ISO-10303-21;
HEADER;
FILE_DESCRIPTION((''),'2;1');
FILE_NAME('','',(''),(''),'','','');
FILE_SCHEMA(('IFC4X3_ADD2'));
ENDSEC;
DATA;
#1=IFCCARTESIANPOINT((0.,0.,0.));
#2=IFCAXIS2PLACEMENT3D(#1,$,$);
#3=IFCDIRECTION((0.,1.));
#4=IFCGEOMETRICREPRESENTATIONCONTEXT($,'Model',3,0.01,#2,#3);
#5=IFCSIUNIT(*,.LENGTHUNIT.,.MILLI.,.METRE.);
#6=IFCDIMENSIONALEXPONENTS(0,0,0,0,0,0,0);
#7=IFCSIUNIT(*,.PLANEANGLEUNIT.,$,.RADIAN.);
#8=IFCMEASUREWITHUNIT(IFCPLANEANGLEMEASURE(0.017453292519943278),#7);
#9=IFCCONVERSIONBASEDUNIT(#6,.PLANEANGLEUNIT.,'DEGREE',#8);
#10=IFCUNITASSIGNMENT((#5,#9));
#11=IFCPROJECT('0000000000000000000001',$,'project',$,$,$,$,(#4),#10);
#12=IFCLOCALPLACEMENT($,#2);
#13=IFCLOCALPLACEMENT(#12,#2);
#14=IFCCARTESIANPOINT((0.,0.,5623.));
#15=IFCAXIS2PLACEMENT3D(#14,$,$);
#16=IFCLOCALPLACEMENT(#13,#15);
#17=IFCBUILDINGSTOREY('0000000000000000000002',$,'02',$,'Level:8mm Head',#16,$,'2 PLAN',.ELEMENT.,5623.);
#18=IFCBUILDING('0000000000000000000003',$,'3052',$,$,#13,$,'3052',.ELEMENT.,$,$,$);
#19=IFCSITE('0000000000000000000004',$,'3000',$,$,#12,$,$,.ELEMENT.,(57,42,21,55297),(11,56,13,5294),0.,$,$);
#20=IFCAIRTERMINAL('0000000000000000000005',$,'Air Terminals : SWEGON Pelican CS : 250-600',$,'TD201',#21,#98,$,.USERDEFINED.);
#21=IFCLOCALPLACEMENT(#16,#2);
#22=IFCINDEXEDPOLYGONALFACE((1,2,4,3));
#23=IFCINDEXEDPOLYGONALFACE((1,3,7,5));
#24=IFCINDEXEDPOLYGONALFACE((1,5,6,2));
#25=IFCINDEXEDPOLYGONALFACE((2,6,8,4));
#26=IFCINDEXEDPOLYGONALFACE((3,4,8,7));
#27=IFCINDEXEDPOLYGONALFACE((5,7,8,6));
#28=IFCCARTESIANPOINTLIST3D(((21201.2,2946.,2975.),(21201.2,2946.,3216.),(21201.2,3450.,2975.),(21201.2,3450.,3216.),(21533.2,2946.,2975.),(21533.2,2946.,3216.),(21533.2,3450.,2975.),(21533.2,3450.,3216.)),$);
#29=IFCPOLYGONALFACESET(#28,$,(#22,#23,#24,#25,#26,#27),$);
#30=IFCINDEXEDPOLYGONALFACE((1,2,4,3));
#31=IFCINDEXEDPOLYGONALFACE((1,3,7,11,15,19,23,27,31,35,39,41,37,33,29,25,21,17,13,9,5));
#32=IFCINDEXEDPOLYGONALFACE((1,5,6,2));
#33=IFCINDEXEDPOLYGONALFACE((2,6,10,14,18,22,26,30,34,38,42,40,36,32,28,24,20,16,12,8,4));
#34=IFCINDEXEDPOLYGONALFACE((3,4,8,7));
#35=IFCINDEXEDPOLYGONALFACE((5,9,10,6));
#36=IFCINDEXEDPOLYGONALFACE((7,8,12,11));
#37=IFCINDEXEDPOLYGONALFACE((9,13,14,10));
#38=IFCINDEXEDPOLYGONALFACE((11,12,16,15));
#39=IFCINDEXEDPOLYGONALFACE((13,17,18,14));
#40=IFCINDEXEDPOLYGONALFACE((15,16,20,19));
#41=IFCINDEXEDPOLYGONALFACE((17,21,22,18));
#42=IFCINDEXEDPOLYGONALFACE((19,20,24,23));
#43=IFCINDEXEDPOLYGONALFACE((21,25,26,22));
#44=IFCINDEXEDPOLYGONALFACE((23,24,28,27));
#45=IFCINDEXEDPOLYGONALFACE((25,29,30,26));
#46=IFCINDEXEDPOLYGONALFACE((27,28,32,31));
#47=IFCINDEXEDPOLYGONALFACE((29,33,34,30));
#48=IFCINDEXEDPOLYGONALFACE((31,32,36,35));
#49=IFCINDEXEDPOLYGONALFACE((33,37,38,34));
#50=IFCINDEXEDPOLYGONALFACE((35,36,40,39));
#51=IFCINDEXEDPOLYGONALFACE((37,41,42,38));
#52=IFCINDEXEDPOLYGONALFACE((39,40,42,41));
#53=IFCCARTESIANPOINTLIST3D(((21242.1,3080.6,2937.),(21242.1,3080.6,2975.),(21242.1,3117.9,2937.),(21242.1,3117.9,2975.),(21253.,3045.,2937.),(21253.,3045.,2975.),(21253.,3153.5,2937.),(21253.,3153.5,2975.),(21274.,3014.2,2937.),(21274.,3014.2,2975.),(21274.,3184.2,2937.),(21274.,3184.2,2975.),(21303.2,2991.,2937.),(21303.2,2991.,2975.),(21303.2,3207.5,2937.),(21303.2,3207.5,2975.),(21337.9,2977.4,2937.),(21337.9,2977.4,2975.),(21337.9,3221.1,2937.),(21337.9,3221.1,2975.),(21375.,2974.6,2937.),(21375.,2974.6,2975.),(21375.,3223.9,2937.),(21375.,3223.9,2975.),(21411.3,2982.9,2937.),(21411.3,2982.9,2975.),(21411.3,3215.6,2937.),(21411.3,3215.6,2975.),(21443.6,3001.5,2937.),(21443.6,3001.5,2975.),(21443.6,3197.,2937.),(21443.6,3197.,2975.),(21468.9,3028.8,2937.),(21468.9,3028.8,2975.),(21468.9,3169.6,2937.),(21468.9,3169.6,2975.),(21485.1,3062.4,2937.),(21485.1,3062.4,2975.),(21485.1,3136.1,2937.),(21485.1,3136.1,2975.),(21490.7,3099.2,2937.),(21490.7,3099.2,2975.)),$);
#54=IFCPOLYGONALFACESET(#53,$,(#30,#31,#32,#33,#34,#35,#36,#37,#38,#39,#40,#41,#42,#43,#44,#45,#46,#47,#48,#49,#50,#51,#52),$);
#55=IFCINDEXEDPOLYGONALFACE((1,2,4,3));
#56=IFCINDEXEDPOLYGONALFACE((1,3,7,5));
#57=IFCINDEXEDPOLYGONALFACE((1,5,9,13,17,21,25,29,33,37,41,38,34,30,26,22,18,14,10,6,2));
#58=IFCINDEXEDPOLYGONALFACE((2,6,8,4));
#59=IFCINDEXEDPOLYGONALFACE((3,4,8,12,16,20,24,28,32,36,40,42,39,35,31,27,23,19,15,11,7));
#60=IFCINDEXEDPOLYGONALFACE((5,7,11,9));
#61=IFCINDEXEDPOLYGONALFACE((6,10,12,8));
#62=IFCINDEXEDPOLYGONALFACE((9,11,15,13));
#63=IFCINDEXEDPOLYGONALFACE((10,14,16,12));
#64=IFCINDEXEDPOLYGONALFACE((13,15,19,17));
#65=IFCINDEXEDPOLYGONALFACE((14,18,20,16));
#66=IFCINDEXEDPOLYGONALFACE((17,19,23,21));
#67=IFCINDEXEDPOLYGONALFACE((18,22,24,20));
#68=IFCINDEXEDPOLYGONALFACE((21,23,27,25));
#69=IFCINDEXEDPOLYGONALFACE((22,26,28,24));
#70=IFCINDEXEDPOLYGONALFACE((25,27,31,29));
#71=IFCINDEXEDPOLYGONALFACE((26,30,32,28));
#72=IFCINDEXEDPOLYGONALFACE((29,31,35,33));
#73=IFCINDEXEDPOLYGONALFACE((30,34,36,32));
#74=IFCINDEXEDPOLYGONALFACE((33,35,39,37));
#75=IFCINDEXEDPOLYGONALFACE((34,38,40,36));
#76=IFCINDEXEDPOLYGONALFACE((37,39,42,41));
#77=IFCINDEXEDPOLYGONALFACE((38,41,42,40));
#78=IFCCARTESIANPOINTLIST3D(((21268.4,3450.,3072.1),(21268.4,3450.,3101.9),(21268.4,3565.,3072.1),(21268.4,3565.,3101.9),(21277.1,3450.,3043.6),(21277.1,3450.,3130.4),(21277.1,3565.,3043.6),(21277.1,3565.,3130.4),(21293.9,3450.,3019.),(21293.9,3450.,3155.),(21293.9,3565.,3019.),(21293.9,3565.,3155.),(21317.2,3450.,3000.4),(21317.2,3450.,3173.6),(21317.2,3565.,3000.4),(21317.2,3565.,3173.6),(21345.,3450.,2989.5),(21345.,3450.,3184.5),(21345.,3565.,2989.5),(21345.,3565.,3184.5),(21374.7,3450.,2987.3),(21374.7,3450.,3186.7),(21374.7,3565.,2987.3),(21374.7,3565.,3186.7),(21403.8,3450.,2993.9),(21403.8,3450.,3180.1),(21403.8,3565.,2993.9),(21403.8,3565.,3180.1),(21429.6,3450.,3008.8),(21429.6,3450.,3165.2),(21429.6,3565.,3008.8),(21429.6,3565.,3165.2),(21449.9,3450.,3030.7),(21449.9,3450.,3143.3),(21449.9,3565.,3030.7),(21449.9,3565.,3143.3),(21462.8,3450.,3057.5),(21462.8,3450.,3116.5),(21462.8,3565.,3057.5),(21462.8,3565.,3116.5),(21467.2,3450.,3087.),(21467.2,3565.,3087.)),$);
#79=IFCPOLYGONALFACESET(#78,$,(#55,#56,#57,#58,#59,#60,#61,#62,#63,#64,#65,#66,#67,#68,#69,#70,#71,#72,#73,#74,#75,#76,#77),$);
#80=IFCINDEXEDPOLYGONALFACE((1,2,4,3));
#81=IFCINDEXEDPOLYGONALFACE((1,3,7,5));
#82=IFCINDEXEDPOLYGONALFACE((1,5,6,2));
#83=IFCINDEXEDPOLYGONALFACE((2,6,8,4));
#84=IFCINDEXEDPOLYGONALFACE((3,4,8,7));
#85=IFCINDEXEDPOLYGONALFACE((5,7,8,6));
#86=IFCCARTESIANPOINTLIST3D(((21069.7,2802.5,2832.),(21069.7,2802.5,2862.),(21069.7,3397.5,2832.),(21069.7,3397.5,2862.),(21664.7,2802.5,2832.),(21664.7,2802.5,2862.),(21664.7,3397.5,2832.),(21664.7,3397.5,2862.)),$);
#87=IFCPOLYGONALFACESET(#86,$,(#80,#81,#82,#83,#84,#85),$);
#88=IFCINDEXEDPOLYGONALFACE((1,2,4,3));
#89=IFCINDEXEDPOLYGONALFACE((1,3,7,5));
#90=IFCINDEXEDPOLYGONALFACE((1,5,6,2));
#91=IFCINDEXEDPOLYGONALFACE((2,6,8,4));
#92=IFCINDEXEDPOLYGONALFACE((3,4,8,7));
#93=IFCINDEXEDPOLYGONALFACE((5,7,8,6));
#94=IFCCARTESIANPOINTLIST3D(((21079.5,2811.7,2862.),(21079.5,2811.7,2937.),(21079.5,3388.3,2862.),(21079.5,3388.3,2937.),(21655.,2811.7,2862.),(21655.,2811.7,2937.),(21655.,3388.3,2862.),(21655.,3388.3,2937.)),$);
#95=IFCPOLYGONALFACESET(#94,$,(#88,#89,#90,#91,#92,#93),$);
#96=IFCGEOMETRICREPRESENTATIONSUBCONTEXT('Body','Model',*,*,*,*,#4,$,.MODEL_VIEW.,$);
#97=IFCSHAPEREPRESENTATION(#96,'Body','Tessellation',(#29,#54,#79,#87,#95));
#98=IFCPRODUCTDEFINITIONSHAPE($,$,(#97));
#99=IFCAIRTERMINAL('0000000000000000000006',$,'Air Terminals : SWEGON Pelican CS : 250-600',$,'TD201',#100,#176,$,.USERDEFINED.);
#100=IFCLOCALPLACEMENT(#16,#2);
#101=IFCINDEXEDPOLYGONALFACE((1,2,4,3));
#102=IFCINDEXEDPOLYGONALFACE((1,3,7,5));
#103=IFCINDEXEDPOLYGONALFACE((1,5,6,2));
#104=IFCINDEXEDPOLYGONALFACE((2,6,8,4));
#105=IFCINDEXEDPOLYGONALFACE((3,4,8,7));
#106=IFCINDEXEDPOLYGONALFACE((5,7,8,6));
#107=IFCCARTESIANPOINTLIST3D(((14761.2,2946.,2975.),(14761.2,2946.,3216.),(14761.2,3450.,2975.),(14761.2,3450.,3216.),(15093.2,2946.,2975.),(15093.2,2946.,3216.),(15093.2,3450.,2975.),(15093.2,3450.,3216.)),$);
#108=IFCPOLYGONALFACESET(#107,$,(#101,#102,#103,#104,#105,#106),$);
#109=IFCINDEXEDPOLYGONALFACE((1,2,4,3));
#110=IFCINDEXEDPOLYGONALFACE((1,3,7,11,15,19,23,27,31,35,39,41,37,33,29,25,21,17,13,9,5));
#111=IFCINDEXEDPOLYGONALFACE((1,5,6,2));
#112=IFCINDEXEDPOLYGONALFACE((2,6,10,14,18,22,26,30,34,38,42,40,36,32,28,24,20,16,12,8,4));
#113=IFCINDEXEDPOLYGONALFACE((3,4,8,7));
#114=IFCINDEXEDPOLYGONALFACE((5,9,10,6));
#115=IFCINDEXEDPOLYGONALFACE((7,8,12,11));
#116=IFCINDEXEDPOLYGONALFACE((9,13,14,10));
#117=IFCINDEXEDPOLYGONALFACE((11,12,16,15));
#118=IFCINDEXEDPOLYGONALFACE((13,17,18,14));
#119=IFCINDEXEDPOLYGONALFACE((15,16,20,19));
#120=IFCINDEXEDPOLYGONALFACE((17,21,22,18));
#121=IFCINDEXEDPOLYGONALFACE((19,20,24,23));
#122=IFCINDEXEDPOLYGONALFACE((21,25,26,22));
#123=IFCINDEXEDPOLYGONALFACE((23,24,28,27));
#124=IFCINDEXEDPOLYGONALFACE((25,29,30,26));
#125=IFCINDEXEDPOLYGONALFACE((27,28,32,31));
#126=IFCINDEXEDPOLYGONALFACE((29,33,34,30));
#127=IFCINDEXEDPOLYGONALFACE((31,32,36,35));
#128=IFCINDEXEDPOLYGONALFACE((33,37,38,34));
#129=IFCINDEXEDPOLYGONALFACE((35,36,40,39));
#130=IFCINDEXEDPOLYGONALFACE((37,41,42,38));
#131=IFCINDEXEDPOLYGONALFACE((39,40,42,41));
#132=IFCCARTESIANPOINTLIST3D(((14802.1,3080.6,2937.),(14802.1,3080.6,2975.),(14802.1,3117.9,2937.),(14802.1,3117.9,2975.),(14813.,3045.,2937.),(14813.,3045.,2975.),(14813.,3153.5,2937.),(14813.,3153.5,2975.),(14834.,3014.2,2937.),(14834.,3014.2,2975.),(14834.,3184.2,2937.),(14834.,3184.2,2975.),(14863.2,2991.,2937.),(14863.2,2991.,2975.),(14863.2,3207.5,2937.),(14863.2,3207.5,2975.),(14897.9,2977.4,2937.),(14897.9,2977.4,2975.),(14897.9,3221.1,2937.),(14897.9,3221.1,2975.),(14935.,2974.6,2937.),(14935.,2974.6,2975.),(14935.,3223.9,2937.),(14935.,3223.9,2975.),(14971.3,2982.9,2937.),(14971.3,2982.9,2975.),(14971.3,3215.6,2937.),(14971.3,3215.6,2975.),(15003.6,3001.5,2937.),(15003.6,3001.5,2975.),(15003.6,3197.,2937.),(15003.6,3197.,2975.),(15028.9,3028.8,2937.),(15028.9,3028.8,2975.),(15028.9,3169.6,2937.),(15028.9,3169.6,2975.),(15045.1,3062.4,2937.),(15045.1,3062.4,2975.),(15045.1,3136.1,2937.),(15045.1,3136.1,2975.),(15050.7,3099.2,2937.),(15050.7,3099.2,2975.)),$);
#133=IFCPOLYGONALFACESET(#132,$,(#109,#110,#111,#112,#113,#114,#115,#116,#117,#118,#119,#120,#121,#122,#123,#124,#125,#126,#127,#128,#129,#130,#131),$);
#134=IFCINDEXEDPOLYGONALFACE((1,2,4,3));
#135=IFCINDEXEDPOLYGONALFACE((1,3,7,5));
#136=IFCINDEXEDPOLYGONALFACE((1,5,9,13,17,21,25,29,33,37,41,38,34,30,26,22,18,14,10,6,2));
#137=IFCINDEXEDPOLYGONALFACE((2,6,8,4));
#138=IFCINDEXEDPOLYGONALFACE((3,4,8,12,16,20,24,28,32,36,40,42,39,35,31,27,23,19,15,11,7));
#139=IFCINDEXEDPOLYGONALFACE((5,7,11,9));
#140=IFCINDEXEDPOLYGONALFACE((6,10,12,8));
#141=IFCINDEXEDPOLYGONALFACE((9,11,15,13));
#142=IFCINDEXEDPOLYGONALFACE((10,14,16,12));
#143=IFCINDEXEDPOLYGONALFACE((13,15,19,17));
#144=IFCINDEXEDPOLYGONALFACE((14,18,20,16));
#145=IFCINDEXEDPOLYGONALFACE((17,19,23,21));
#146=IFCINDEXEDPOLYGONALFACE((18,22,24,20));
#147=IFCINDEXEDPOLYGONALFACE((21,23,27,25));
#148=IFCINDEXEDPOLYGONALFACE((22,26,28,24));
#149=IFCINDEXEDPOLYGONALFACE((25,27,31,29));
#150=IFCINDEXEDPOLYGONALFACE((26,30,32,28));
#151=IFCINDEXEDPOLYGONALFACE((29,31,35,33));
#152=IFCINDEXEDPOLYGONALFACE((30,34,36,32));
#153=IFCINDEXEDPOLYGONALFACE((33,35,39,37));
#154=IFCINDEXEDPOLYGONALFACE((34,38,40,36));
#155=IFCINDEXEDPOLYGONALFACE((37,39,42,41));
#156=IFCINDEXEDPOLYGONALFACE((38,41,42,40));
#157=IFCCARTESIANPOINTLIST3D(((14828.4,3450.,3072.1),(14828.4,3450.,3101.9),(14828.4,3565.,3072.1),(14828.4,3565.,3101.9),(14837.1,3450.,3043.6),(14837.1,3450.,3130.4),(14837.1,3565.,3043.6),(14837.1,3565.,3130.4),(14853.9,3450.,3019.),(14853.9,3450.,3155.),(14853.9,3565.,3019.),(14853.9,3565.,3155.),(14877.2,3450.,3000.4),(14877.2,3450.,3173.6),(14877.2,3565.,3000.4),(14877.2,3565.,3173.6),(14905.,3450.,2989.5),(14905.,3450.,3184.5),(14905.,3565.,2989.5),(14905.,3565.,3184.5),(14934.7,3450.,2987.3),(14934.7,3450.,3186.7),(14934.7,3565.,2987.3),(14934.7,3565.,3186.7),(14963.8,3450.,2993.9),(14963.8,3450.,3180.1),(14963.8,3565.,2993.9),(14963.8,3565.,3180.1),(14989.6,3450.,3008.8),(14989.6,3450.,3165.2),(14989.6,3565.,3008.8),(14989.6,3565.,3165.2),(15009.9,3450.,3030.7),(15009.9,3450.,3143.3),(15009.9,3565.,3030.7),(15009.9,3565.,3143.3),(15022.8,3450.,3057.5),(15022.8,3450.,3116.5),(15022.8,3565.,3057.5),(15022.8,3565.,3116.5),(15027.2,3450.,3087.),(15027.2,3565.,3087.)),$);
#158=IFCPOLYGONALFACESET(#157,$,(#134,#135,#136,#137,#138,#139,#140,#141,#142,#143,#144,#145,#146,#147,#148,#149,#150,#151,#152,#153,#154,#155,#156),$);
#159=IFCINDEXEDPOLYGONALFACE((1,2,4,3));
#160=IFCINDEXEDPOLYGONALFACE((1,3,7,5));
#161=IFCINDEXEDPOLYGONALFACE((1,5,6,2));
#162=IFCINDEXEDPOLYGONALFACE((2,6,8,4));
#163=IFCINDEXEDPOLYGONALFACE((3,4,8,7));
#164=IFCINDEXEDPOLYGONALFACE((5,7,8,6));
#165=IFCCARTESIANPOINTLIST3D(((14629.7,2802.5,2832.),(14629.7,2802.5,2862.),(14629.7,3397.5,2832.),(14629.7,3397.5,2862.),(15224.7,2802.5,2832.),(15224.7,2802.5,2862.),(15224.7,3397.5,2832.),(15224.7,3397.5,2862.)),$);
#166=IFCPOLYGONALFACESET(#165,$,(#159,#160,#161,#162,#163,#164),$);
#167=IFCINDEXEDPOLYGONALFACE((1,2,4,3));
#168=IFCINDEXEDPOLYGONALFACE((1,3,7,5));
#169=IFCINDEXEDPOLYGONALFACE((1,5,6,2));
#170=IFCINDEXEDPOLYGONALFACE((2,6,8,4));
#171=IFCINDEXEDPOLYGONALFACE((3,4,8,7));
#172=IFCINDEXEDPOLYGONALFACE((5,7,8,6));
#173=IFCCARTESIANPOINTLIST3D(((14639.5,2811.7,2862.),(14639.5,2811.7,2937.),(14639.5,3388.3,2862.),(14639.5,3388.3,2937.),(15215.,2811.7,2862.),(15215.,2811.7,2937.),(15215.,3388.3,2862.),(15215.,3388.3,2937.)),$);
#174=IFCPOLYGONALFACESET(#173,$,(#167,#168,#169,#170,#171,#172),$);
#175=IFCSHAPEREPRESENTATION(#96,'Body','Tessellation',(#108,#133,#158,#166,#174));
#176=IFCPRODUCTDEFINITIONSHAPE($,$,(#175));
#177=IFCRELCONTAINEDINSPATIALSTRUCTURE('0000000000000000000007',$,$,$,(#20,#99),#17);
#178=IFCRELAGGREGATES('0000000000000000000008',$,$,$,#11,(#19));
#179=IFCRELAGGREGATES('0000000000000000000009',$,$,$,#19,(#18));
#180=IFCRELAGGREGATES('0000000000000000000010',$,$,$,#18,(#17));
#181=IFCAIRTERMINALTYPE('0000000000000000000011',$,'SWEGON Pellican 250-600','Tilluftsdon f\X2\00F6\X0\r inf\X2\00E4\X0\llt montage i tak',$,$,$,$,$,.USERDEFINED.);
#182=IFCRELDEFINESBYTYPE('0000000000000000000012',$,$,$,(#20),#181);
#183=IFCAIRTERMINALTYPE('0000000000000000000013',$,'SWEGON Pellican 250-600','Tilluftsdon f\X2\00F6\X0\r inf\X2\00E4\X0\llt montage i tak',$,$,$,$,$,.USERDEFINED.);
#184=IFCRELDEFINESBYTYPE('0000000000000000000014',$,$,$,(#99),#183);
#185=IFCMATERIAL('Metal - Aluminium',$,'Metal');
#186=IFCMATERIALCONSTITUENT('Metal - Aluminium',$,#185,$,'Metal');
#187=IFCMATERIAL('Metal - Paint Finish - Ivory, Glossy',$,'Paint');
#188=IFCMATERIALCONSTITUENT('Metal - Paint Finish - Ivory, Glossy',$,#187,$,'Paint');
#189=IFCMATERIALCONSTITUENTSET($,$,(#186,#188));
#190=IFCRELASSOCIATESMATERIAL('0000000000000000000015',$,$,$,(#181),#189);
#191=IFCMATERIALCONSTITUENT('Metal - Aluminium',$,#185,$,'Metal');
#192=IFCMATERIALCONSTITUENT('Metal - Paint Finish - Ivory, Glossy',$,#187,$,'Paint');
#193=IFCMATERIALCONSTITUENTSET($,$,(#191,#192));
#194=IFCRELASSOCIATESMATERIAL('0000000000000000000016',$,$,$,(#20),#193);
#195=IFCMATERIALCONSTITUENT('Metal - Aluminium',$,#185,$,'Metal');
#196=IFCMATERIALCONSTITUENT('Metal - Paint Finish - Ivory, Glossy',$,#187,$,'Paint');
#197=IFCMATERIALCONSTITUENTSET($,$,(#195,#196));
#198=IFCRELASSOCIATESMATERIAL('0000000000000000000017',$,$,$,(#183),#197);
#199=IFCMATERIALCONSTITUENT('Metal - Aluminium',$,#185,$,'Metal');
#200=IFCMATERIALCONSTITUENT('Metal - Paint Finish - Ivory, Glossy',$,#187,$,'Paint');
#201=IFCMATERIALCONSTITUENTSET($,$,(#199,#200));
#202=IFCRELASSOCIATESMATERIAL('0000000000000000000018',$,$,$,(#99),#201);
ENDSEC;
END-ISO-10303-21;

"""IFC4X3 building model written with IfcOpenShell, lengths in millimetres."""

from ifc_helpers import new_model, entity, si_unit, converted_unit, direction, frame, frame_2d, origin, origin_2d_with_axis, place, context, subcontext, project, spatial, rectangle, circle, extrude, source, transform, mapped, material, constituent, constituent_set, type_object, type_shapes, element, save


model = new_model("IFC4X3")

# Units and contexts
model_context = context("Model", 3, precision=0.01, world=origin(), true_north=direction((0.0, 1.0)))
body_context = subcontext(model_context, "Body", "Model", "MODEL_VIEW")
ifc_project = project(units=[si_unit("LENGTHUNIT", "METRE", prefix="MILLI"), converted_unit("PLANEANGLEUNIT", "DEGREE", entity("IfcPlaneAngleMeasure", 0.017453292519943278), si_unit("PLANEANGLEUNIT", "RADIAN"), dimensions=[0, 0, 0, 0, 0, 0, 0])], contexts=[model_context])

# Site, building, storey
site_placement = place(None, origin())
site = spatial("IfcSite", under=ifc_project, at=site_placement, Name="3000", CompositionType="ELEMENT", RefLatitude=(57, 42, 21, 55297), RefLongitude=(11, 56, 13, 5294), RefElevation=0.0)
building_placement = place(site_placement, origin())
building = spatial("IfcBuilding", under=site, at=building_placement, Name="3052", LongName="3052", CompositionType="ELEMENT")
storey_placement = place(building_placement, frame((0.0, 0.0, 5623.0)))
storey = spatial("IfcBuildingStorey", under=building, at=storey_placement, Name="02", ObjectType="Level:8mm Head", LongName="2 PLAN", CompositionType="ELEMENT", Elevation=5623.0)

# Air terminals
ifc_material_1 = material(Name="Metal - Aluminium", Category="Metal")
ifc_material_2 = material(Name="Metal - Paint Finish - Ivory, Glossy", Category="Paint")
ifc_constituent_1 = constituent(ifc_material_1, Name="Metal - Aluminium", Category="Metal")
ifc_constituent_2 = constituent(ifc_material_2, Name="Metal - Paint Finish - Ivory, Glossy", Category="Paint")
ifc_constituent_set_1 = constituent_set(constituents=[ifc_constituent_1, ifc_constituent_2])
air_terminal_type_1 = type_object("IfcAirTerminalType", Name="SWEGON Pellican 250-600", Description="Tilluftsdon för infällt montage i tak", PredefinedType="USERDEFINED", material=ifc_constituent_set_1)
shared_shape_1 = source(origin(), body_context, "Body", "SweptSolid", [
    extrude(rectangle(XDim=504.0, YDim=332.0, at=origin_2d_with_axis()), frame((0.0, -98.0, -354.0), z_axis=(0.0, 0.0, 1.0), x_axis=(0.0, 1.0, 0.0)), (0.0, 0.0, 1.0), 241.0),
    extrude(circle(Radius=125.0, at=frame_2d((0.0, 0.0), x_axis=(1.0, 0.0))), frame((-1.6, 0.8, -113.0)), (0.0, 0.0, 1.0), 38.0),
    extrude(circle(Radius=100.0, at=frame_2d((0.0, 0.0), x_axis=(1.0, 0.0))), frame((0.0, -465.0, -225.0), z_axis=(0.0, 1.0, 0.0), x_axis=(1.0, 0.0, 0.0)), (0.0, 0.0, 1.0), 115.0),
    extrude(rectangle(XDim=595.0, YDim=595.0, at=frame_2d((0.0, 0.0), x_axis=(1.0, 0.0))), frame((0.0, 0.0, 0.0), z_axis=(0.0, 0.0, 1.0), x_axis=(0.0, 1.0, 0.0)), (0.0, 0.0, 1.0), 30.0),
    extrude(rectangle(XDim=576.5, YDim=575.5, at=origin_2d_with_axis()), frame((0.0, 0.0, -75.0), z_axis=(0.0, 0.0, 1.0), x_axis=(0.0, 1.0, 0.0)), (0.0, 0.0, 1.0), 75.0),
])
type_shapes(air_terminal_type_1, [shared_shape_1])
ifc_constituent_3 = constituent(ifc_material_1, Name="Metal - Aluminium", Category="Metal")
ifc_constituent_4 = constituent(ifc_material_2, Name="Metal - Paint Finish - Ivory, Glossy", Category="Paint")
ifc_constituent_set_2 = constituent_set(constituents=[ifc_constituent_3, ifc_constituent_4])
air_terminal_1_placement = place(storey_placement, frame((21367.2, 3100.0, 2862.0), z_axis=(0.0, 0.0, -1.0), x_axis=(1.0, 0.0, 0.0)))
element("IfcAirTerminal", 1, at=air_terminal_1_placement, inside=storey, type_object=air_terminal_type_1, material=ifc_constituent_set_2, Name="Air Terminals : SWEGON Pelican CS : 250-600", ObjectType="TD201", PredefinedType="USERDEFINED", context=body_context, shape_type="MappedRepresentation", body=[
    mapped(shared_shape_1, transform((0.0, 0.0, 0.0), scale=1.0)),
])
ifc_constituent_5 = constituent(ifc_material_1, Name="Metal - Aluminium", Category="Metal")
ifc_constituent_6 = constituent(ifc_material_2, Name="Metal - Paint Finish - Ivory, Glossy", Category="Paint")
ifc_constituent_set_3 = constituent_set(constituents=[ifc_constituent_5, ifc_constituent_6])
ifc_constituent_7 = constituent(ifc_material_1, Name="Metal - Aluminium", Category="Metal")
ifc_constituent_8 = constituent(ifc_material_2, Name="Metal - Paint Finish - Ivory, Glossy", Category="Paint")
ifc_constituent_set_4 = constituent_set(constituents=[ifc_constituent_7, ifc_constituent_8])
air_terminal_type_2 = type_object("IfcAirTerminalType", Name="SWEGON Pellican 250-600", Description="Tilluftsdon för infällt montage i tak", PredefinedType="USERDEFINED", material=ifc_constituent_set_4)
shared_shape_2 = source(origin(), body_context, "Body", "SweptSolid", [
    extrude(rectangle(XDim=504.0, YDim=332.0, at=origin_2d_with_axis()), frame((0.0, -98.0, -354.0), z_axis=(0.0, 0.0, 1.0), x_axis=(0.0, 1.0, 0.0)), (0.0, 0.0, 1.0), 241.0),
    extrude(circle(Radius=125.0, at=frame_2d((0.0, 0.0), x_axis=(1.0, 0.0))), frame((-1.6, 0.8, -113.0)), (0.0, 0.0, 1.0), 38.0),
    extrude(circle(Radius=100.0, at=frame_2d((0.0, 0.0), x_axis=(1.0, 0.0))), frame((0.0, -465.0, -225.0), z_axis=(0.0, 1.0, 0.0), x_axis=(1.0, 0.0, 0.0)), (0.0, 0.0, 1.0), 115.0),
    extrude(rectangle(XDim=595.0, YDim=595.0, at=frame_2d((0.0, 0.0), x_axis=(1.0, 0.0))), frame((0.0, 0.0, 0.0), z_axis=(0.0, 0.0, 1.0), x_axis=(0.0, 1.0, 0.0)), (0.0, 0.0, 1.0), 30.0),
    extrude(rectangle(XDim=576.5, YDim=575.5, at=origin_2d_with_axis()), frame((0.0, 0.0, -75.0), z_axis=(0.0, 0.0, 1.0), x_axis=(0.0, 1.0, 0.0)), (0.0, 0.0, 1.0), 75.0),
])
type_shapes(air_terminal_type_2, [shared_shape_2])
air_terminal_2_placement = place(storey_placement, frame((14927.2, 3100.0, 2862.0), z_axis=(0.0, 0.0, -1.0), x_axis=(1.0, 0.0, 0.0)))
element("IfcAirTerminal", 2, at=air_terminal_2_placement, inside=storey, type_object=air_terminal_type_2, material=ifc_constituent_set_3, Name="Air Terminals : SWEGON Pelican CS : 250-600", ObjectType="TD201", PredefinedType="USERDEFINED", context=body_context, shape_type="MappedRepresentation", body=[
    mapped(shared_shape_2, transform((0.0, 0.0, 0.0), scale=1.0)),
])

save(model, "model.ifc")
